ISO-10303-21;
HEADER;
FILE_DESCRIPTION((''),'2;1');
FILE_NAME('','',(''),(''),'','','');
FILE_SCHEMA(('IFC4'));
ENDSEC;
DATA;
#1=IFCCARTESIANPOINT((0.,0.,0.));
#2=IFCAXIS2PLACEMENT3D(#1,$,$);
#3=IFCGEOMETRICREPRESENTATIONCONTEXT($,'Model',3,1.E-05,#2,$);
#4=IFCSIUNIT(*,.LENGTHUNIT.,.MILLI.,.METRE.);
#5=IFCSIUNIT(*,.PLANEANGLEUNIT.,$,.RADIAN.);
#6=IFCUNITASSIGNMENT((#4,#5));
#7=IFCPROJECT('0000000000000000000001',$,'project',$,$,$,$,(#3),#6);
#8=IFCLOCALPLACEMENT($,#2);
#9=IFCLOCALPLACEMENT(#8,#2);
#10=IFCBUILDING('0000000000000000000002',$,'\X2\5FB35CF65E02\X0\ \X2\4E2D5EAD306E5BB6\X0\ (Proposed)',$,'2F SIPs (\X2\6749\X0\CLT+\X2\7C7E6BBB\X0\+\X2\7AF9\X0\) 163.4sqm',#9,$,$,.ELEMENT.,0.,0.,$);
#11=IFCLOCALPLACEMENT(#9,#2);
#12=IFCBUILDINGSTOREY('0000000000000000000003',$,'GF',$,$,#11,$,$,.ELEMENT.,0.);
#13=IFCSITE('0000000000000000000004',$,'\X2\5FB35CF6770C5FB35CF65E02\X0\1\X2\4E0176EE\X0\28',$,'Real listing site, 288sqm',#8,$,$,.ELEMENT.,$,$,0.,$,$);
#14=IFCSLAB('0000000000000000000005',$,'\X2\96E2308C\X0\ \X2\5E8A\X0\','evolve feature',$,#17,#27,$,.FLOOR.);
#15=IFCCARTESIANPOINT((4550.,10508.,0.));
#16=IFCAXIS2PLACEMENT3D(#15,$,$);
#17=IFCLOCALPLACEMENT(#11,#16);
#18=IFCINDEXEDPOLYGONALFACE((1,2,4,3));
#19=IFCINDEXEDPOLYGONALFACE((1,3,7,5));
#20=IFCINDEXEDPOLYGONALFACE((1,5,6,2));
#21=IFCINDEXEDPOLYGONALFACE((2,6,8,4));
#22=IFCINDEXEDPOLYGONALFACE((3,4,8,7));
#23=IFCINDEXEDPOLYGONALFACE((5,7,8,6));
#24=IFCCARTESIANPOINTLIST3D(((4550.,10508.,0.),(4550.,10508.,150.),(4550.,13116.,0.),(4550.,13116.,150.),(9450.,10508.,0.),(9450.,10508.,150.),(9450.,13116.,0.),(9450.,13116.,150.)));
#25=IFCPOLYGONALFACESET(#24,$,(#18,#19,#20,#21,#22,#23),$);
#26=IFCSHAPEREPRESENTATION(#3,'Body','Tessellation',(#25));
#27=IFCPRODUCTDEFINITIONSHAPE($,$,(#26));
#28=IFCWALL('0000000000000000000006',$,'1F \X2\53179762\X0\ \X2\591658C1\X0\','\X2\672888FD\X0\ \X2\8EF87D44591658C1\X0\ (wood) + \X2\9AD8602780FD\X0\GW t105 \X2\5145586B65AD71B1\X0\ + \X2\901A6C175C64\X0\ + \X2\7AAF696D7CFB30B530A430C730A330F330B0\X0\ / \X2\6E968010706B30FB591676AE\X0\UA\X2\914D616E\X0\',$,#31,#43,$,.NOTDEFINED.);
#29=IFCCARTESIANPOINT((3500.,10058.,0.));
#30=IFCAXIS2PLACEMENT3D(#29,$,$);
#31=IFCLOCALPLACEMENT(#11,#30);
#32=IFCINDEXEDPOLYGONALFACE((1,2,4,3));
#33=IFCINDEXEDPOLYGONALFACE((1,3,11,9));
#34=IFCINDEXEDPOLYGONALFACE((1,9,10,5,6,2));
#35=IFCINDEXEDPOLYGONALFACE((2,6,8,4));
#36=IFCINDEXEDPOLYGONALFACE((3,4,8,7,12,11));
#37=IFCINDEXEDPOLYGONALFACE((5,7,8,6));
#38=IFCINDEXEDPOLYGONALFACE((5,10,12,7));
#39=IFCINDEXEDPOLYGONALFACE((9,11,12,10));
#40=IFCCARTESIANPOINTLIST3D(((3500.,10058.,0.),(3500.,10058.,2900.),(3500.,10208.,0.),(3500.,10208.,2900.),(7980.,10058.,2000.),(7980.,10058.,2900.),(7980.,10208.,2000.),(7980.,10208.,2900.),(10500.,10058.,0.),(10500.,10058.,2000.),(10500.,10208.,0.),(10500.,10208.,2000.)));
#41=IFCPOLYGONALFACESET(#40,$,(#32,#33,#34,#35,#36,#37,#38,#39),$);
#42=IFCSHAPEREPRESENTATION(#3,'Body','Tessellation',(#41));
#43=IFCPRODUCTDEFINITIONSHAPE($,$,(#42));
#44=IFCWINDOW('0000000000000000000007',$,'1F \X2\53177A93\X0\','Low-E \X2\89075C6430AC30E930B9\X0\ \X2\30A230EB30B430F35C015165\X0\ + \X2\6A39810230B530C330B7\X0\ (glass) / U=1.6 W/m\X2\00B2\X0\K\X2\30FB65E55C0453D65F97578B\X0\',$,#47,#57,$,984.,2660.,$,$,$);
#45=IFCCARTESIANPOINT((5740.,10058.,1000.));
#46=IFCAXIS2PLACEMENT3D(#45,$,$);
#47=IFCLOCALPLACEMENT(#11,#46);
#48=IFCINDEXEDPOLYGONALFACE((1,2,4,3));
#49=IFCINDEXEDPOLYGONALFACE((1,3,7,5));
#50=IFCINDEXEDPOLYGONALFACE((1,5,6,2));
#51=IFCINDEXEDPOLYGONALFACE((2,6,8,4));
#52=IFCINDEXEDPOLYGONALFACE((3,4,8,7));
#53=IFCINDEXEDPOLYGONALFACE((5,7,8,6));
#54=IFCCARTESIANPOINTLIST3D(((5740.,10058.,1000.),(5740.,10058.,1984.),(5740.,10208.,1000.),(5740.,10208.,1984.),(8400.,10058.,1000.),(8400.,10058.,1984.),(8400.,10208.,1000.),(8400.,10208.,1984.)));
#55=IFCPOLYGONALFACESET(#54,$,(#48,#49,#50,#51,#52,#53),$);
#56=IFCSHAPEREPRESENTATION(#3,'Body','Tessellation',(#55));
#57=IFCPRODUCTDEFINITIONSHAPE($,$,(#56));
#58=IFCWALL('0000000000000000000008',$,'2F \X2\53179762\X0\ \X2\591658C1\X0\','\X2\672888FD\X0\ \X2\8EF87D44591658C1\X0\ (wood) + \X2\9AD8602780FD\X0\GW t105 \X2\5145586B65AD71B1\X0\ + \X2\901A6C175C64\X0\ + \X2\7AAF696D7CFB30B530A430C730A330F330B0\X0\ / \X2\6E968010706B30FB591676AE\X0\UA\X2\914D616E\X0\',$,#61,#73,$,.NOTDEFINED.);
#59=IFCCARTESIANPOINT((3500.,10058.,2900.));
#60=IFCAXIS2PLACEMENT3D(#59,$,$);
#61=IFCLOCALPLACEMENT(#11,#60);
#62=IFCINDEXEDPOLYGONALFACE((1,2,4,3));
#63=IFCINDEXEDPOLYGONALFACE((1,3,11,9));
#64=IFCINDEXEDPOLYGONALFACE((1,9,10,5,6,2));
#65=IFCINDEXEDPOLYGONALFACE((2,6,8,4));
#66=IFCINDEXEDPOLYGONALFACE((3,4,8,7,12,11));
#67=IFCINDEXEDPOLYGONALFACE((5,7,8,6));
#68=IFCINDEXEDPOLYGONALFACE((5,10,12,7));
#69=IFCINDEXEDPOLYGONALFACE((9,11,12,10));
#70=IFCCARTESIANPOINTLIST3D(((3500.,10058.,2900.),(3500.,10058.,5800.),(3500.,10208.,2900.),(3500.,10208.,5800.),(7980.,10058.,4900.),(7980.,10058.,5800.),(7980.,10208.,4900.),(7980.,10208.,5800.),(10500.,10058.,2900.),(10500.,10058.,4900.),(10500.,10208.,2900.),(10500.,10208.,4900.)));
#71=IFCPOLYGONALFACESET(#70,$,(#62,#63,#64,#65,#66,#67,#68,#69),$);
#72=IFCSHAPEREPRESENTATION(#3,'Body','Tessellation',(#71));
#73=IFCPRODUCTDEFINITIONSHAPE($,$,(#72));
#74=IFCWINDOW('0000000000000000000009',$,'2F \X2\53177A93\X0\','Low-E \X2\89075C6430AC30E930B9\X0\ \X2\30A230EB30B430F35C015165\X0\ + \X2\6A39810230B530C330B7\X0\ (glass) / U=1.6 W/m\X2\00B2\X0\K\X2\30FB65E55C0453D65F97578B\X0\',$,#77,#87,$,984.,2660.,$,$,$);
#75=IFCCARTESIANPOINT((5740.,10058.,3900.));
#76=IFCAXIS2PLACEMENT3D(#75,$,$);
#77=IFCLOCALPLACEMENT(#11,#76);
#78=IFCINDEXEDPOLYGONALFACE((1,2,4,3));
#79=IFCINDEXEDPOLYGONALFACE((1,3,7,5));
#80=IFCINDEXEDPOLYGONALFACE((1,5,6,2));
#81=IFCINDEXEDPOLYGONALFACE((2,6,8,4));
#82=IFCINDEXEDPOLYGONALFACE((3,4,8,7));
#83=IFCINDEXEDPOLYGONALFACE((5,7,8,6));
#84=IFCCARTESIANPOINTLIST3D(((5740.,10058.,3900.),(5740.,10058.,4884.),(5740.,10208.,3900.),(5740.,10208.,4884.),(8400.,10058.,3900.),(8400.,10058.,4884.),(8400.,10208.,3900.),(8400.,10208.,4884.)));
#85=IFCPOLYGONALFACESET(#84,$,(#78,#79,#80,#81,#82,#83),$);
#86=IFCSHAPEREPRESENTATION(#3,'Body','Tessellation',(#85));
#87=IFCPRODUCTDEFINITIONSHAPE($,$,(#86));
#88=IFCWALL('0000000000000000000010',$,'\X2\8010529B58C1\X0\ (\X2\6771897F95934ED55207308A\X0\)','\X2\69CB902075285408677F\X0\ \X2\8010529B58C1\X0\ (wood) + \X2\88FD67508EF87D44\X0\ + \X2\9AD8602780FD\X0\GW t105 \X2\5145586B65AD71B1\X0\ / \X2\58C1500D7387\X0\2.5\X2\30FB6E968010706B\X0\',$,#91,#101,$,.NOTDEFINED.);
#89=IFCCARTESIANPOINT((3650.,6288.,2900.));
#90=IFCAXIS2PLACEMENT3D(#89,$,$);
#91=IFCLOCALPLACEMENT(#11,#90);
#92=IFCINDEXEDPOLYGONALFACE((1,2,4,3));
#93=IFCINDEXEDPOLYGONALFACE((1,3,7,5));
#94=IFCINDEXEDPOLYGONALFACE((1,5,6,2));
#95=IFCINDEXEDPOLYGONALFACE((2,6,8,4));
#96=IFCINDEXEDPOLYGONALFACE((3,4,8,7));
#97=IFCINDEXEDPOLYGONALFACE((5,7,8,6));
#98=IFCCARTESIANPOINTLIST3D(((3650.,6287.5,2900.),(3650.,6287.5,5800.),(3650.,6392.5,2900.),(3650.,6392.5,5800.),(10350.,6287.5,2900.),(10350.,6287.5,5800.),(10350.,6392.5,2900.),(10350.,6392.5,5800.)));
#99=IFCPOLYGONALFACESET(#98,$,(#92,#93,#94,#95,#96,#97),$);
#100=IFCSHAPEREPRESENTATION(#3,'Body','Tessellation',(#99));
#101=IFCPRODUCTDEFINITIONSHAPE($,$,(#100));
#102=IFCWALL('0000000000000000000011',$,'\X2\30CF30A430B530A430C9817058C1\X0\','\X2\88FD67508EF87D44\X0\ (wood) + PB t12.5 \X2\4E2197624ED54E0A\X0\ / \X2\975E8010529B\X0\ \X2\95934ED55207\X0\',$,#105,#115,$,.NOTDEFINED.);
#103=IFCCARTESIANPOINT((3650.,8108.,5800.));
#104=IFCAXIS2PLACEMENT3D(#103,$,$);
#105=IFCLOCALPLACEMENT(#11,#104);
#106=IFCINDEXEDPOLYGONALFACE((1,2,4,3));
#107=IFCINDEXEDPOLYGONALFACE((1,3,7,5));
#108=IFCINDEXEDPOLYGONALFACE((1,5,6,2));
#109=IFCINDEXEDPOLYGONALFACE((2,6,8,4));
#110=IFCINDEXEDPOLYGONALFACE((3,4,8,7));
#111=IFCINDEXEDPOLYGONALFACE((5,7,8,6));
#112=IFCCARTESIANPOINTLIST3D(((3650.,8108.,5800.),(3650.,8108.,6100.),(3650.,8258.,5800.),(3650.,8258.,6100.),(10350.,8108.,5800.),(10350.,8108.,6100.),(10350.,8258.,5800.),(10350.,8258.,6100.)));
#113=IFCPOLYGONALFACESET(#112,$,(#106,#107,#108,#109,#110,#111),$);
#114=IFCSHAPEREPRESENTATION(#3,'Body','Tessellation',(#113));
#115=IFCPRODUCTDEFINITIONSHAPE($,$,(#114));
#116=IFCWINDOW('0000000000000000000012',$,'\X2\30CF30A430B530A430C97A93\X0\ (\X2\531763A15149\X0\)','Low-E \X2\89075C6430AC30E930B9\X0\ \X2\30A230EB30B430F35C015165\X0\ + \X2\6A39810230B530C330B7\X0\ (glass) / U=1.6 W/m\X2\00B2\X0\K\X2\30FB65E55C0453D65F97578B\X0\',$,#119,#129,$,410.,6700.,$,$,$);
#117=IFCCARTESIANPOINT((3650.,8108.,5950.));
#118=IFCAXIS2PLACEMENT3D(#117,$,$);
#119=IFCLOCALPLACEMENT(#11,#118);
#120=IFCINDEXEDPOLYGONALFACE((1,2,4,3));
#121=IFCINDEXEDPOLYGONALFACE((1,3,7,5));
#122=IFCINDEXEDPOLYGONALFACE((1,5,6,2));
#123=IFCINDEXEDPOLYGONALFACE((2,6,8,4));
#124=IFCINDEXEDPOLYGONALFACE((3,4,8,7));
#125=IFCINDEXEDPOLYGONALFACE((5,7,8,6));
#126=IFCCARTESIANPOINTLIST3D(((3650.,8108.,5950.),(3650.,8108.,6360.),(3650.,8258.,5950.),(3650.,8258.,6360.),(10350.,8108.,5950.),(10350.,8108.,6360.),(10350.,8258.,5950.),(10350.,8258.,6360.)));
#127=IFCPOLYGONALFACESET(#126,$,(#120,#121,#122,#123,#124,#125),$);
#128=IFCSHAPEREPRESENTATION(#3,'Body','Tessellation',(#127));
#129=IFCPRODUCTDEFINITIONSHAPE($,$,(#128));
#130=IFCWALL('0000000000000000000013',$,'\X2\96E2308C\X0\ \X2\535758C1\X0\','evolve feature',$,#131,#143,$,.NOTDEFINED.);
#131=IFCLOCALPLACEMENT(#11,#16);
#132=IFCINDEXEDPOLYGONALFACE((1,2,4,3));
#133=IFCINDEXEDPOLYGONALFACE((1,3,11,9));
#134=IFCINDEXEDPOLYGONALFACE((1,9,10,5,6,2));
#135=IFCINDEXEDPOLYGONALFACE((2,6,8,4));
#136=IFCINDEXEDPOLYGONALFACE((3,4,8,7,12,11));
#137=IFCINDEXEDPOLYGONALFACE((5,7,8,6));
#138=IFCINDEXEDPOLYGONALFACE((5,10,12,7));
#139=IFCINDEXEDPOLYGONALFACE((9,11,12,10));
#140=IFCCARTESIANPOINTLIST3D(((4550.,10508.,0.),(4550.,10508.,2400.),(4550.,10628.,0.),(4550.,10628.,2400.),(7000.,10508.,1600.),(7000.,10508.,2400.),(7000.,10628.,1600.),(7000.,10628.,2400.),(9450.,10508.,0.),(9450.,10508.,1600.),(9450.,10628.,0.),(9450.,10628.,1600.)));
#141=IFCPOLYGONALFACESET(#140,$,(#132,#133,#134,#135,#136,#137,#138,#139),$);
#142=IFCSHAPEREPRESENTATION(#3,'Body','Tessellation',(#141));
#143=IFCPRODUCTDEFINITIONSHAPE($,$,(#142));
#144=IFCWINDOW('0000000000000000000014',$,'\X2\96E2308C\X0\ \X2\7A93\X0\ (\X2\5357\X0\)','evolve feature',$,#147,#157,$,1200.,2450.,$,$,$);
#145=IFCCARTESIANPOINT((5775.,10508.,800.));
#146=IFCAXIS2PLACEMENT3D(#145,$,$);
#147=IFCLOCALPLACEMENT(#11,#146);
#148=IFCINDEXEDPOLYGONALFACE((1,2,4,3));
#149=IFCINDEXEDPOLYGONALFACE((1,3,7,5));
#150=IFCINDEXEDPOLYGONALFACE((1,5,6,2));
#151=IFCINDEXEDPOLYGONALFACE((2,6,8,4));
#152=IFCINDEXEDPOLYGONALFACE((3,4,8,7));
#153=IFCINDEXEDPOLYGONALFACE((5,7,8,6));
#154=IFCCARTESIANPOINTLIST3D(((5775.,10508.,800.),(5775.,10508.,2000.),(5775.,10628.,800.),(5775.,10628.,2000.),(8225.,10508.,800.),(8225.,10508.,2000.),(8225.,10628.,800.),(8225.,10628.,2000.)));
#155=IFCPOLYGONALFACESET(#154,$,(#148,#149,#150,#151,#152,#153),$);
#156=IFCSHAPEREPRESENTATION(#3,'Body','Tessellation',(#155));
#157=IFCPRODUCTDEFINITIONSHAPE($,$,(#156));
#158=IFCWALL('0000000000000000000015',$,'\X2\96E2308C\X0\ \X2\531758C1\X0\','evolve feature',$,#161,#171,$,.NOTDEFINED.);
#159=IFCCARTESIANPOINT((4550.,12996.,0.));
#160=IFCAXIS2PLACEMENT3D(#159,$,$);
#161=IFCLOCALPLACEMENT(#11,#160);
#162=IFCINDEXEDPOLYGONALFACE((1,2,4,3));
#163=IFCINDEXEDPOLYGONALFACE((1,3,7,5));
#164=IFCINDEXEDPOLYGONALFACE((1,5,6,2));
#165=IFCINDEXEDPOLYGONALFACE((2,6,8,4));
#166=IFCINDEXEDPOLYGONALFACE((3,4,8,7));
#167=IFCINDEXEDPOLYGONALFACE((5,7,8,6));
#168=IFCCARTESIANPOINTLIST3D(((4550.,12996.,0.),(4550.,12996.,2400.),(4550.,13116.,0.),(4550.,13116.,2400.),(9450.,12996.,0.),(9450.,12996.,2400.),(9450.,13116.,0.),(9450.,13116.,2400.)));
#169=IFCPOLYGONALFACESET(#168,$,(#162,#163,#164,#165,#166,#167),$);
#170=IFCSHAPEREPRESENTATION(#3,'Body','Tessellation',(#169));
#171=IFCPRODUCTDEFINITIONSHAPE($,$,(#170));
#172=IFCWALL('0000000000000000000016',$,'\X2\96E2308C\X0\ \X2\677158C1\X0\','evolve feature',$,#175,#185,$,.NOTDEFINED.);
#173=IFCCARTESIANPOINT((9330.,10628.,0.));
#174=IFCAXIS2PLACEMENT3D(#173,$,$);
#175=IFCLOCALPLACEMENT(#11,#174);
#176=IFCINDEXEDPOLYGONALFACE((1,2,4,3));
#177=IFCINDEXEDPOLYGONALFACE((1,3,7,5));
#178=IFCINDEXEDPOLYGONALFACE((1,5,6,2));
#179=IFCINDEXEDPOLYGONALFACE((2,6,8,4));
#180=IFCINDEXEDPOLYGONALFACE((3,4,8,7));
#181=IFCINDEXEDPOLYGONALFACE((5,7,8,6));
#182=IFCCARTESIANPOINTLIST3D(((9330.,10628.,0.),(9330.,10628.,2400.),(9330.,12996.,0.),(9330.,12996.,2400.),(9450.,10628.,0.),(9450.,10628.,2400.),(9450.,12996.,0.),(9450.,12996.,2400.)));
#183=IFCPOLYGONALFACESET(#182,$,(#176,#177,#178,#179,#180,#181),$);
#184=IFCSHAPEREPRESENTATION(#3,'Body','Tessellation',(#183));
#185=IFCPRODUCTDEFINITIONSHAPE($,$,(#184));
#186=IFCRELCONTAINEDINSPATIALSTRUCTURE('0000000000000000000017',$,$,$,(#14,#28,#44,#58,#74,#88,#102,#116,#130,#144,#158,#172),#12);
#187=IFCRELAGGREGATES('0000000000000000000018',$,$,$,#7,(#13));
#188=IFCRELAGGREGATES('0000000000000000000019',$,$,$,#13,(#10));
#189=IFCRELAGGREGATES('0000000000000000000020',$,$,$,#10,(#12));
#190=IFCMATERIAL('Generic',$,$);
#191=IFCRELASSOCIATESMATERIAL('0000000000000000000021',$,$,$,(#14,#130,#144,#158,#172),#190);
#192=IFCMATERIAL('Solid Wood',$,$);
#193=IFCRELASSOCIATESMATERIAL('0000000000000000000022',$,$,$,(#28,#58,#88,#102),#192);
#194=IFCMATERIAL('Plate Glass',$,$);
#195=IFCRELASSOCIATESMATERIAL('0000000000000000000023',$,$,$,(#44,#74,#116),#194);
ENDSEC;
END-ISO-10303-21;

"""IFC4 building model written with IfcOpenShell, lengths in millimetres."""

from ifc_helpers import new_model, si_unit, frame, frame_2d, origin, place, context, project, spatial, rectangle, extrude, material, element, fill, save


model = new_model("IFC4")

# Units and contexts
model_context = context("Model", 3, precision=1e-05, world=origin())
ifc_project = project(units=[si_unit("LENGTHUNIT", "METRE", prefix="MILLI"), si_unit("PLANEANGLEUNIT", "RADIAN")], contexts=[model_context])

# Site, building, storey
site_placement = place(None, origin())
site = spatial("IfcSite", under=ifc_project, at=site_placement, Name="徳島県徳島市1丁目28", ObjectType="Real listing site, 288sqm", CompositionType="ELEMENT", RefElevation=0.0)
building_placement = place(site_placement, origin())
building = spatial("IfcBuilding", under=site, at=building_placement, Name="徳島市 中庭の家 (Proposed)", ObjectType="2F SIPs (杉CLT+籾殻+竹) 163.4sqm", CompositionType="ELEMENT", ElevationOfRefHeight=0.0, ElevationOfTerrain=0.0)
storey_placement = place(building_placement, origin())
storey = spatial("IfcBuildingStorey", under=building, at=storey_placement, Name="GF", CompositionType="ELEMENT", Elevation=0.0)

# Slab
ifc_material_1 = material(Name="Generic")
slab_placement = place(storey_placement, frame((4550.0, 10508.0, 0.0)))
element("IfcSlab", 1, at=slab_placement, inside=storey, material=ifc_material_1, Name="離れ 床", Description="evolve feature", PredefinedType="FLOOR", context=model_context, shape_type="SweptSolid", body=[
    extrude(rectangle(XDim=4900.0, YDim=2608.0, at=frame_2d((2450.0, 1304.0))), frame((4550.0, 10508.0, 0.0)), (0.0, 0.0, 1.0), 150.0),
])

# Wall, opening, window
ifc_material_2 = material(Name="Solid Wood")
wall_1_placement = place(storey_placement, frame((3500.0, 10058.0, 0.0)))
wall_1 = element("IfcWall", 2, at=wall_1_placement, inside=storey, material=ifc_material_2, Name="1F 北面 外壁", Description="木製 軸組外壁 (wood) + 高性能GW t105 充填断熱 + 通気層 + 窯業系サイディング / 準耐火・外皮UA配慮", PredefinedType="NOTDEFINED", context=model_context, shape_type="SweptSolid", body=[
    extrude(rectangle(XDim=7000.0, YDim=150.0, at=frame_2d((3500.0, 75.0))), frame((3500.0, 10058.0, 0.0)), (0.0, 0.0, 1.0), 2900.0),
])
opening_1_placement = place(storey_placement, frame((5740.0, 10058.0, 1000.0)))
opening_1 = element("IfcOpeningElement", 3, at=opening_1_placement, cuts=wall_1, PredefinedType="NOTDEFINED", context=model_context, shape_type="SweptSolid", body=[
    extrude(rectangle(XDim=2660.0, YDim=150.0, at=frame_2d((1330.0, 75.0))), frame((5740.0, 10058.0, 1000.0)), (0.0, 0.0, 1.0), 984.0),
])
ifc_material_3 = material(Name="Plate Glass")
window_1_placement = place(storey_placement, frame((5740.0, 10058.0, 1000.0)))
window_1 = element("IfcWindow", 4, at=window_1_placement, inside=storey, material=ifc_material_3, Name="1F 北窓", Description="Low-E 複層ガラス アルゴン封入 + 樹脂サッシ (glass) / U=1.6 W/m²K・日射取得型", OverallHeight=984.0, OverallWidth=2660.0, context=model_context, shape_type="SweptSolid", body=[
    extrude(rectangle(XDim=2660.0, YDim=150.0, at=frame_2d((1330.0, 75.0))), frame((5740.0, 10058.0, 1000.0)), (0.0, 0.0, 1.0), 984.0),
])
fill(opening_1, window_1)

# Wall, opening, window
wall_2_placement = place(storey_placement, frame((3500.0, 10058.0, 2900.0)))
wall_2 = element("IfcWall", 5, at=wall_2_placement, inside=storey, material=ifc_material_2, Name="2F 北面 外壁", Description="木製 軸組外壁 (wood) + 高性能GW t105 充填断熱 + 通気層 + 窯業系サイディング / 準耐火・外皮UA配慮", PredefinedType="NOTDEFINED", context=model_context, shape_type="SweptSolid", body=[
    extrude(rectangle(XDim=7000.0, YDim=150.0, at=frame_2d((3500.0, 75.0))), frame((3500.0, 10058.0, 2900.0)), (0.0, 0.0, 1.0), 2900.0),
])
opening_2_placement = place(storey_placement, frame((5740.0, 10058.0, 3900.0)))
opening_2 = element("IfcOpeningElement", 6, at=opening_2_placement, cuts=wall_2, PredefinedType="NOTDEFINED", context=model_context, shape_type="SweptSolid", body=[
    extrude(rectangle(XDim=2660.0, YDim=150.0, at=frame_2d((1330.0, 75.0))), frame((5740.0, 10058.0, 3900.0)), (0.0, 0.0, 1.0), 984.0),
])
window_2_placement = place(storey_placement, frame((5740.0, 10058.0, 3900.0)))
window_2 = element("IfcWindow", 7, at=window_2_placement, inside=storey, material=ifc_material_3, Name="2F 北窓", Description="Low-E 複層ガラス アルゴン封入 + 樹脂サッシ (glass) / U=1.6 W/m²K・日射取得型", OverallHeight=984.0, OverallWidth=2660.0, context=model_context, shape_type="SweptSolid", body=[
    extrude(rectangle(XDim=2660.0, YDim=150.0, at=frame_2d((1330.0, 75.0))), frame((5740.0, 10058.0, 3900.0)), (0.0, 0.0, 1.0), 984.0),
])
fill(opening_2, window_2)

# Wall
wall_3_placement = place(storey_placement, frame((3650.0, 6288.0, 2900.0)))
element("IfcWall", 8, at=wall_3_placement, inside=storey, material=ifc_material_2, Name="耐力壁 (東西間仕切り)", Description="構造用合板 耐力壁 (wood) + 製材軸組 + 高性能GW t105 充填断熱 / 壁倍率2.5・準耐火", PredefinedType="NOTDEFINED", context=model_context, shape_type="SweptSolid", body=[
    extrude(rectangle(XDim=6700.0, YDim=105.0, at=frame_2d((3350.0, 52.0))), frame((3650.0, 6288.0, 2900.0)), (0.0, 0.0, 1.0), 2900.0),
])

# Walls, openings, windows
wall_4_placement = place(storey_placement, frame((3650.0, 8108.0, 5800.0)))
wall_4 = element("IfcWall", 9, at=wall_4_placement, inside=storey, material=ifc_material_2, Name="ハイサイド腰壁", Description="製材軸組 (wood) + PB t12.5 両面仕上 / 非耐力 間仕切", PredefinedType="NOTDEFINED", context=model_context, shape_type="SweptSolid", body=[
    extrude(rectangle(XDim=6700.0, YDim=150.0, at=frame_2d((3350.0, 75.0))), frame((3650.0, 8108.0, 5800.0)), (0.0, 0.0, 1.0), 700.0),
])
opening_3_placement = place(storey_placement, frame((3650.0, 8108.0, 5950.0)))
opening_3 = element("IfcOpeningElement", 10, at=opening_3_placement, cuts=wall_4, PredefinedType="NOTDEFINED", context=model_context, shape_type="SweptSolid", body=[
    extrude(rectangle(XDim=6700.0, YDim=150.0, at=frame_2d((3350.0, 75.0))), frame((3650.0, 8108.0, 5950.0)), (0.0, 0.0, 1.0), 410.0),
])
window_3_placement = place(storey_placement, frame((3650.0, 8108.0, 5950.0)))
window_3 = element("IfcWindow", 11, at=window_3_placement, inside=storey, material=ifc_material_3, Name="ハイサイド窓 (北採光)", Description="Low-E 複層ガラス アルゴン封入 + 樹脂サッシ (glass) / U=1.6 W/m²K・日射取得型", OverallHeight=410.0, OverallWidth=6700.0, context=model_context, shape_type="SweptSolid", body=[
    extrude(rectangle(XDim=6700.0, YDim=150.0, at=frame_2d((3350.0, 75.0))), frame((3650.0, 8108.0, 5950.0)), (0.0, 0.0, 1.0), 410.0),
])
fill(opening_3, window_3)
wall_5_placement = place(storey_placement, frame((4550.0, 10508.0, 0.0)))
wall_5 = element("IfcWall", 12, at=wall_5_placement, inside=storey, material=ifc_material_1, Name="離れ 南壁", Description="evolve feature", PredefinedType="NOTDEFINED", context=model_context, shape_type="SweptSolid", body=[
    extrude(rectangle(XDim=4900.0, YDim=120.0, at=frame_2d((2450.0, 60.0))), frame((4550.0, 10508.0, 0.0)), (0.0, 0.0, 1.0), 2400.0),
])
opening_4_placement = place(storey_placement, frame((5775.0, 10508.0, 800.0)))
opening_4 = element("IfcOpeningElement", 13, at=opening_4_placement, cuts=wall_5, PredefinedType="NOTDEFINED", context=model_context, shape_type="SweptSolid", body=[
    extrude(rectangle(XDim=2450.0, YDim=120.0, at=frame_2d((1225.0, 60.0))), frame((5775.0, 10508.0, 800.0)), (0.0, 0.0, 1.0), 1200.0),
])
window_4_placement = place(storey_placement, frame((5775.0, 10508.0, 800.0)))
window_4 = element("IfcWindow", 14, at=window_4_placement, inside=storey, material=ifc_material_1, Name="離れ 窓 (南)", Description="evolve feature", OverallHeight=1200.0, OverallWidth=2450.0, context=model_context, shape_type="SweptSolid", body=[
    extrude(rectangle(XDim=2450.0, YDim=120.0, at=frame_2d((1225.0, 60.0))), frame((5775.0, 10508.0, 800.0)), (0.0, 0.0, 1.0), 1200.0),
])
fill(opening_4, window_4)

# Walls
wall_6_placement = place(storey_placement, frame((4550.0, 12996.0, 0.0)))
element("IfcWall", 15, at=wall_6_placement, inside=storey, material=ifc_material_1, Name="離れ 北壁", Description="evolve feature", PredefinedType="NOTDEFINED", context=model_context, shape_type="SweptSolid", body=[
    extrude(rectangle(XDim=4900.0, YDim=120.0, at=frame_2d((2450.0, 60.0))), frame((4550.0, 12996.0, 0.0)), (0.0, 0.0, 1.0), 2400.0),
])
wall_7_placement = place(storey_placement, frame((9330.0, 10628.0, 0.0)))
element("IfcWall", 16, at=wall_7_placement, inside=storey, material=ifc_material_1, Name="離れ 東壁", Description="evolve feature", PredefinedType="NOTDEFINED", context=model_context, shape_type="SweptSolid", body=[
    extrude(rectangle(XDim=120.0, YDim=2368.0, at=frame_2d((60.0, 1184.0))), frame((9330.0, 10628.0, 0.0)), (0.0, 0.0, 1.0), 2400.0),
])

save(model, "model.ifc")
